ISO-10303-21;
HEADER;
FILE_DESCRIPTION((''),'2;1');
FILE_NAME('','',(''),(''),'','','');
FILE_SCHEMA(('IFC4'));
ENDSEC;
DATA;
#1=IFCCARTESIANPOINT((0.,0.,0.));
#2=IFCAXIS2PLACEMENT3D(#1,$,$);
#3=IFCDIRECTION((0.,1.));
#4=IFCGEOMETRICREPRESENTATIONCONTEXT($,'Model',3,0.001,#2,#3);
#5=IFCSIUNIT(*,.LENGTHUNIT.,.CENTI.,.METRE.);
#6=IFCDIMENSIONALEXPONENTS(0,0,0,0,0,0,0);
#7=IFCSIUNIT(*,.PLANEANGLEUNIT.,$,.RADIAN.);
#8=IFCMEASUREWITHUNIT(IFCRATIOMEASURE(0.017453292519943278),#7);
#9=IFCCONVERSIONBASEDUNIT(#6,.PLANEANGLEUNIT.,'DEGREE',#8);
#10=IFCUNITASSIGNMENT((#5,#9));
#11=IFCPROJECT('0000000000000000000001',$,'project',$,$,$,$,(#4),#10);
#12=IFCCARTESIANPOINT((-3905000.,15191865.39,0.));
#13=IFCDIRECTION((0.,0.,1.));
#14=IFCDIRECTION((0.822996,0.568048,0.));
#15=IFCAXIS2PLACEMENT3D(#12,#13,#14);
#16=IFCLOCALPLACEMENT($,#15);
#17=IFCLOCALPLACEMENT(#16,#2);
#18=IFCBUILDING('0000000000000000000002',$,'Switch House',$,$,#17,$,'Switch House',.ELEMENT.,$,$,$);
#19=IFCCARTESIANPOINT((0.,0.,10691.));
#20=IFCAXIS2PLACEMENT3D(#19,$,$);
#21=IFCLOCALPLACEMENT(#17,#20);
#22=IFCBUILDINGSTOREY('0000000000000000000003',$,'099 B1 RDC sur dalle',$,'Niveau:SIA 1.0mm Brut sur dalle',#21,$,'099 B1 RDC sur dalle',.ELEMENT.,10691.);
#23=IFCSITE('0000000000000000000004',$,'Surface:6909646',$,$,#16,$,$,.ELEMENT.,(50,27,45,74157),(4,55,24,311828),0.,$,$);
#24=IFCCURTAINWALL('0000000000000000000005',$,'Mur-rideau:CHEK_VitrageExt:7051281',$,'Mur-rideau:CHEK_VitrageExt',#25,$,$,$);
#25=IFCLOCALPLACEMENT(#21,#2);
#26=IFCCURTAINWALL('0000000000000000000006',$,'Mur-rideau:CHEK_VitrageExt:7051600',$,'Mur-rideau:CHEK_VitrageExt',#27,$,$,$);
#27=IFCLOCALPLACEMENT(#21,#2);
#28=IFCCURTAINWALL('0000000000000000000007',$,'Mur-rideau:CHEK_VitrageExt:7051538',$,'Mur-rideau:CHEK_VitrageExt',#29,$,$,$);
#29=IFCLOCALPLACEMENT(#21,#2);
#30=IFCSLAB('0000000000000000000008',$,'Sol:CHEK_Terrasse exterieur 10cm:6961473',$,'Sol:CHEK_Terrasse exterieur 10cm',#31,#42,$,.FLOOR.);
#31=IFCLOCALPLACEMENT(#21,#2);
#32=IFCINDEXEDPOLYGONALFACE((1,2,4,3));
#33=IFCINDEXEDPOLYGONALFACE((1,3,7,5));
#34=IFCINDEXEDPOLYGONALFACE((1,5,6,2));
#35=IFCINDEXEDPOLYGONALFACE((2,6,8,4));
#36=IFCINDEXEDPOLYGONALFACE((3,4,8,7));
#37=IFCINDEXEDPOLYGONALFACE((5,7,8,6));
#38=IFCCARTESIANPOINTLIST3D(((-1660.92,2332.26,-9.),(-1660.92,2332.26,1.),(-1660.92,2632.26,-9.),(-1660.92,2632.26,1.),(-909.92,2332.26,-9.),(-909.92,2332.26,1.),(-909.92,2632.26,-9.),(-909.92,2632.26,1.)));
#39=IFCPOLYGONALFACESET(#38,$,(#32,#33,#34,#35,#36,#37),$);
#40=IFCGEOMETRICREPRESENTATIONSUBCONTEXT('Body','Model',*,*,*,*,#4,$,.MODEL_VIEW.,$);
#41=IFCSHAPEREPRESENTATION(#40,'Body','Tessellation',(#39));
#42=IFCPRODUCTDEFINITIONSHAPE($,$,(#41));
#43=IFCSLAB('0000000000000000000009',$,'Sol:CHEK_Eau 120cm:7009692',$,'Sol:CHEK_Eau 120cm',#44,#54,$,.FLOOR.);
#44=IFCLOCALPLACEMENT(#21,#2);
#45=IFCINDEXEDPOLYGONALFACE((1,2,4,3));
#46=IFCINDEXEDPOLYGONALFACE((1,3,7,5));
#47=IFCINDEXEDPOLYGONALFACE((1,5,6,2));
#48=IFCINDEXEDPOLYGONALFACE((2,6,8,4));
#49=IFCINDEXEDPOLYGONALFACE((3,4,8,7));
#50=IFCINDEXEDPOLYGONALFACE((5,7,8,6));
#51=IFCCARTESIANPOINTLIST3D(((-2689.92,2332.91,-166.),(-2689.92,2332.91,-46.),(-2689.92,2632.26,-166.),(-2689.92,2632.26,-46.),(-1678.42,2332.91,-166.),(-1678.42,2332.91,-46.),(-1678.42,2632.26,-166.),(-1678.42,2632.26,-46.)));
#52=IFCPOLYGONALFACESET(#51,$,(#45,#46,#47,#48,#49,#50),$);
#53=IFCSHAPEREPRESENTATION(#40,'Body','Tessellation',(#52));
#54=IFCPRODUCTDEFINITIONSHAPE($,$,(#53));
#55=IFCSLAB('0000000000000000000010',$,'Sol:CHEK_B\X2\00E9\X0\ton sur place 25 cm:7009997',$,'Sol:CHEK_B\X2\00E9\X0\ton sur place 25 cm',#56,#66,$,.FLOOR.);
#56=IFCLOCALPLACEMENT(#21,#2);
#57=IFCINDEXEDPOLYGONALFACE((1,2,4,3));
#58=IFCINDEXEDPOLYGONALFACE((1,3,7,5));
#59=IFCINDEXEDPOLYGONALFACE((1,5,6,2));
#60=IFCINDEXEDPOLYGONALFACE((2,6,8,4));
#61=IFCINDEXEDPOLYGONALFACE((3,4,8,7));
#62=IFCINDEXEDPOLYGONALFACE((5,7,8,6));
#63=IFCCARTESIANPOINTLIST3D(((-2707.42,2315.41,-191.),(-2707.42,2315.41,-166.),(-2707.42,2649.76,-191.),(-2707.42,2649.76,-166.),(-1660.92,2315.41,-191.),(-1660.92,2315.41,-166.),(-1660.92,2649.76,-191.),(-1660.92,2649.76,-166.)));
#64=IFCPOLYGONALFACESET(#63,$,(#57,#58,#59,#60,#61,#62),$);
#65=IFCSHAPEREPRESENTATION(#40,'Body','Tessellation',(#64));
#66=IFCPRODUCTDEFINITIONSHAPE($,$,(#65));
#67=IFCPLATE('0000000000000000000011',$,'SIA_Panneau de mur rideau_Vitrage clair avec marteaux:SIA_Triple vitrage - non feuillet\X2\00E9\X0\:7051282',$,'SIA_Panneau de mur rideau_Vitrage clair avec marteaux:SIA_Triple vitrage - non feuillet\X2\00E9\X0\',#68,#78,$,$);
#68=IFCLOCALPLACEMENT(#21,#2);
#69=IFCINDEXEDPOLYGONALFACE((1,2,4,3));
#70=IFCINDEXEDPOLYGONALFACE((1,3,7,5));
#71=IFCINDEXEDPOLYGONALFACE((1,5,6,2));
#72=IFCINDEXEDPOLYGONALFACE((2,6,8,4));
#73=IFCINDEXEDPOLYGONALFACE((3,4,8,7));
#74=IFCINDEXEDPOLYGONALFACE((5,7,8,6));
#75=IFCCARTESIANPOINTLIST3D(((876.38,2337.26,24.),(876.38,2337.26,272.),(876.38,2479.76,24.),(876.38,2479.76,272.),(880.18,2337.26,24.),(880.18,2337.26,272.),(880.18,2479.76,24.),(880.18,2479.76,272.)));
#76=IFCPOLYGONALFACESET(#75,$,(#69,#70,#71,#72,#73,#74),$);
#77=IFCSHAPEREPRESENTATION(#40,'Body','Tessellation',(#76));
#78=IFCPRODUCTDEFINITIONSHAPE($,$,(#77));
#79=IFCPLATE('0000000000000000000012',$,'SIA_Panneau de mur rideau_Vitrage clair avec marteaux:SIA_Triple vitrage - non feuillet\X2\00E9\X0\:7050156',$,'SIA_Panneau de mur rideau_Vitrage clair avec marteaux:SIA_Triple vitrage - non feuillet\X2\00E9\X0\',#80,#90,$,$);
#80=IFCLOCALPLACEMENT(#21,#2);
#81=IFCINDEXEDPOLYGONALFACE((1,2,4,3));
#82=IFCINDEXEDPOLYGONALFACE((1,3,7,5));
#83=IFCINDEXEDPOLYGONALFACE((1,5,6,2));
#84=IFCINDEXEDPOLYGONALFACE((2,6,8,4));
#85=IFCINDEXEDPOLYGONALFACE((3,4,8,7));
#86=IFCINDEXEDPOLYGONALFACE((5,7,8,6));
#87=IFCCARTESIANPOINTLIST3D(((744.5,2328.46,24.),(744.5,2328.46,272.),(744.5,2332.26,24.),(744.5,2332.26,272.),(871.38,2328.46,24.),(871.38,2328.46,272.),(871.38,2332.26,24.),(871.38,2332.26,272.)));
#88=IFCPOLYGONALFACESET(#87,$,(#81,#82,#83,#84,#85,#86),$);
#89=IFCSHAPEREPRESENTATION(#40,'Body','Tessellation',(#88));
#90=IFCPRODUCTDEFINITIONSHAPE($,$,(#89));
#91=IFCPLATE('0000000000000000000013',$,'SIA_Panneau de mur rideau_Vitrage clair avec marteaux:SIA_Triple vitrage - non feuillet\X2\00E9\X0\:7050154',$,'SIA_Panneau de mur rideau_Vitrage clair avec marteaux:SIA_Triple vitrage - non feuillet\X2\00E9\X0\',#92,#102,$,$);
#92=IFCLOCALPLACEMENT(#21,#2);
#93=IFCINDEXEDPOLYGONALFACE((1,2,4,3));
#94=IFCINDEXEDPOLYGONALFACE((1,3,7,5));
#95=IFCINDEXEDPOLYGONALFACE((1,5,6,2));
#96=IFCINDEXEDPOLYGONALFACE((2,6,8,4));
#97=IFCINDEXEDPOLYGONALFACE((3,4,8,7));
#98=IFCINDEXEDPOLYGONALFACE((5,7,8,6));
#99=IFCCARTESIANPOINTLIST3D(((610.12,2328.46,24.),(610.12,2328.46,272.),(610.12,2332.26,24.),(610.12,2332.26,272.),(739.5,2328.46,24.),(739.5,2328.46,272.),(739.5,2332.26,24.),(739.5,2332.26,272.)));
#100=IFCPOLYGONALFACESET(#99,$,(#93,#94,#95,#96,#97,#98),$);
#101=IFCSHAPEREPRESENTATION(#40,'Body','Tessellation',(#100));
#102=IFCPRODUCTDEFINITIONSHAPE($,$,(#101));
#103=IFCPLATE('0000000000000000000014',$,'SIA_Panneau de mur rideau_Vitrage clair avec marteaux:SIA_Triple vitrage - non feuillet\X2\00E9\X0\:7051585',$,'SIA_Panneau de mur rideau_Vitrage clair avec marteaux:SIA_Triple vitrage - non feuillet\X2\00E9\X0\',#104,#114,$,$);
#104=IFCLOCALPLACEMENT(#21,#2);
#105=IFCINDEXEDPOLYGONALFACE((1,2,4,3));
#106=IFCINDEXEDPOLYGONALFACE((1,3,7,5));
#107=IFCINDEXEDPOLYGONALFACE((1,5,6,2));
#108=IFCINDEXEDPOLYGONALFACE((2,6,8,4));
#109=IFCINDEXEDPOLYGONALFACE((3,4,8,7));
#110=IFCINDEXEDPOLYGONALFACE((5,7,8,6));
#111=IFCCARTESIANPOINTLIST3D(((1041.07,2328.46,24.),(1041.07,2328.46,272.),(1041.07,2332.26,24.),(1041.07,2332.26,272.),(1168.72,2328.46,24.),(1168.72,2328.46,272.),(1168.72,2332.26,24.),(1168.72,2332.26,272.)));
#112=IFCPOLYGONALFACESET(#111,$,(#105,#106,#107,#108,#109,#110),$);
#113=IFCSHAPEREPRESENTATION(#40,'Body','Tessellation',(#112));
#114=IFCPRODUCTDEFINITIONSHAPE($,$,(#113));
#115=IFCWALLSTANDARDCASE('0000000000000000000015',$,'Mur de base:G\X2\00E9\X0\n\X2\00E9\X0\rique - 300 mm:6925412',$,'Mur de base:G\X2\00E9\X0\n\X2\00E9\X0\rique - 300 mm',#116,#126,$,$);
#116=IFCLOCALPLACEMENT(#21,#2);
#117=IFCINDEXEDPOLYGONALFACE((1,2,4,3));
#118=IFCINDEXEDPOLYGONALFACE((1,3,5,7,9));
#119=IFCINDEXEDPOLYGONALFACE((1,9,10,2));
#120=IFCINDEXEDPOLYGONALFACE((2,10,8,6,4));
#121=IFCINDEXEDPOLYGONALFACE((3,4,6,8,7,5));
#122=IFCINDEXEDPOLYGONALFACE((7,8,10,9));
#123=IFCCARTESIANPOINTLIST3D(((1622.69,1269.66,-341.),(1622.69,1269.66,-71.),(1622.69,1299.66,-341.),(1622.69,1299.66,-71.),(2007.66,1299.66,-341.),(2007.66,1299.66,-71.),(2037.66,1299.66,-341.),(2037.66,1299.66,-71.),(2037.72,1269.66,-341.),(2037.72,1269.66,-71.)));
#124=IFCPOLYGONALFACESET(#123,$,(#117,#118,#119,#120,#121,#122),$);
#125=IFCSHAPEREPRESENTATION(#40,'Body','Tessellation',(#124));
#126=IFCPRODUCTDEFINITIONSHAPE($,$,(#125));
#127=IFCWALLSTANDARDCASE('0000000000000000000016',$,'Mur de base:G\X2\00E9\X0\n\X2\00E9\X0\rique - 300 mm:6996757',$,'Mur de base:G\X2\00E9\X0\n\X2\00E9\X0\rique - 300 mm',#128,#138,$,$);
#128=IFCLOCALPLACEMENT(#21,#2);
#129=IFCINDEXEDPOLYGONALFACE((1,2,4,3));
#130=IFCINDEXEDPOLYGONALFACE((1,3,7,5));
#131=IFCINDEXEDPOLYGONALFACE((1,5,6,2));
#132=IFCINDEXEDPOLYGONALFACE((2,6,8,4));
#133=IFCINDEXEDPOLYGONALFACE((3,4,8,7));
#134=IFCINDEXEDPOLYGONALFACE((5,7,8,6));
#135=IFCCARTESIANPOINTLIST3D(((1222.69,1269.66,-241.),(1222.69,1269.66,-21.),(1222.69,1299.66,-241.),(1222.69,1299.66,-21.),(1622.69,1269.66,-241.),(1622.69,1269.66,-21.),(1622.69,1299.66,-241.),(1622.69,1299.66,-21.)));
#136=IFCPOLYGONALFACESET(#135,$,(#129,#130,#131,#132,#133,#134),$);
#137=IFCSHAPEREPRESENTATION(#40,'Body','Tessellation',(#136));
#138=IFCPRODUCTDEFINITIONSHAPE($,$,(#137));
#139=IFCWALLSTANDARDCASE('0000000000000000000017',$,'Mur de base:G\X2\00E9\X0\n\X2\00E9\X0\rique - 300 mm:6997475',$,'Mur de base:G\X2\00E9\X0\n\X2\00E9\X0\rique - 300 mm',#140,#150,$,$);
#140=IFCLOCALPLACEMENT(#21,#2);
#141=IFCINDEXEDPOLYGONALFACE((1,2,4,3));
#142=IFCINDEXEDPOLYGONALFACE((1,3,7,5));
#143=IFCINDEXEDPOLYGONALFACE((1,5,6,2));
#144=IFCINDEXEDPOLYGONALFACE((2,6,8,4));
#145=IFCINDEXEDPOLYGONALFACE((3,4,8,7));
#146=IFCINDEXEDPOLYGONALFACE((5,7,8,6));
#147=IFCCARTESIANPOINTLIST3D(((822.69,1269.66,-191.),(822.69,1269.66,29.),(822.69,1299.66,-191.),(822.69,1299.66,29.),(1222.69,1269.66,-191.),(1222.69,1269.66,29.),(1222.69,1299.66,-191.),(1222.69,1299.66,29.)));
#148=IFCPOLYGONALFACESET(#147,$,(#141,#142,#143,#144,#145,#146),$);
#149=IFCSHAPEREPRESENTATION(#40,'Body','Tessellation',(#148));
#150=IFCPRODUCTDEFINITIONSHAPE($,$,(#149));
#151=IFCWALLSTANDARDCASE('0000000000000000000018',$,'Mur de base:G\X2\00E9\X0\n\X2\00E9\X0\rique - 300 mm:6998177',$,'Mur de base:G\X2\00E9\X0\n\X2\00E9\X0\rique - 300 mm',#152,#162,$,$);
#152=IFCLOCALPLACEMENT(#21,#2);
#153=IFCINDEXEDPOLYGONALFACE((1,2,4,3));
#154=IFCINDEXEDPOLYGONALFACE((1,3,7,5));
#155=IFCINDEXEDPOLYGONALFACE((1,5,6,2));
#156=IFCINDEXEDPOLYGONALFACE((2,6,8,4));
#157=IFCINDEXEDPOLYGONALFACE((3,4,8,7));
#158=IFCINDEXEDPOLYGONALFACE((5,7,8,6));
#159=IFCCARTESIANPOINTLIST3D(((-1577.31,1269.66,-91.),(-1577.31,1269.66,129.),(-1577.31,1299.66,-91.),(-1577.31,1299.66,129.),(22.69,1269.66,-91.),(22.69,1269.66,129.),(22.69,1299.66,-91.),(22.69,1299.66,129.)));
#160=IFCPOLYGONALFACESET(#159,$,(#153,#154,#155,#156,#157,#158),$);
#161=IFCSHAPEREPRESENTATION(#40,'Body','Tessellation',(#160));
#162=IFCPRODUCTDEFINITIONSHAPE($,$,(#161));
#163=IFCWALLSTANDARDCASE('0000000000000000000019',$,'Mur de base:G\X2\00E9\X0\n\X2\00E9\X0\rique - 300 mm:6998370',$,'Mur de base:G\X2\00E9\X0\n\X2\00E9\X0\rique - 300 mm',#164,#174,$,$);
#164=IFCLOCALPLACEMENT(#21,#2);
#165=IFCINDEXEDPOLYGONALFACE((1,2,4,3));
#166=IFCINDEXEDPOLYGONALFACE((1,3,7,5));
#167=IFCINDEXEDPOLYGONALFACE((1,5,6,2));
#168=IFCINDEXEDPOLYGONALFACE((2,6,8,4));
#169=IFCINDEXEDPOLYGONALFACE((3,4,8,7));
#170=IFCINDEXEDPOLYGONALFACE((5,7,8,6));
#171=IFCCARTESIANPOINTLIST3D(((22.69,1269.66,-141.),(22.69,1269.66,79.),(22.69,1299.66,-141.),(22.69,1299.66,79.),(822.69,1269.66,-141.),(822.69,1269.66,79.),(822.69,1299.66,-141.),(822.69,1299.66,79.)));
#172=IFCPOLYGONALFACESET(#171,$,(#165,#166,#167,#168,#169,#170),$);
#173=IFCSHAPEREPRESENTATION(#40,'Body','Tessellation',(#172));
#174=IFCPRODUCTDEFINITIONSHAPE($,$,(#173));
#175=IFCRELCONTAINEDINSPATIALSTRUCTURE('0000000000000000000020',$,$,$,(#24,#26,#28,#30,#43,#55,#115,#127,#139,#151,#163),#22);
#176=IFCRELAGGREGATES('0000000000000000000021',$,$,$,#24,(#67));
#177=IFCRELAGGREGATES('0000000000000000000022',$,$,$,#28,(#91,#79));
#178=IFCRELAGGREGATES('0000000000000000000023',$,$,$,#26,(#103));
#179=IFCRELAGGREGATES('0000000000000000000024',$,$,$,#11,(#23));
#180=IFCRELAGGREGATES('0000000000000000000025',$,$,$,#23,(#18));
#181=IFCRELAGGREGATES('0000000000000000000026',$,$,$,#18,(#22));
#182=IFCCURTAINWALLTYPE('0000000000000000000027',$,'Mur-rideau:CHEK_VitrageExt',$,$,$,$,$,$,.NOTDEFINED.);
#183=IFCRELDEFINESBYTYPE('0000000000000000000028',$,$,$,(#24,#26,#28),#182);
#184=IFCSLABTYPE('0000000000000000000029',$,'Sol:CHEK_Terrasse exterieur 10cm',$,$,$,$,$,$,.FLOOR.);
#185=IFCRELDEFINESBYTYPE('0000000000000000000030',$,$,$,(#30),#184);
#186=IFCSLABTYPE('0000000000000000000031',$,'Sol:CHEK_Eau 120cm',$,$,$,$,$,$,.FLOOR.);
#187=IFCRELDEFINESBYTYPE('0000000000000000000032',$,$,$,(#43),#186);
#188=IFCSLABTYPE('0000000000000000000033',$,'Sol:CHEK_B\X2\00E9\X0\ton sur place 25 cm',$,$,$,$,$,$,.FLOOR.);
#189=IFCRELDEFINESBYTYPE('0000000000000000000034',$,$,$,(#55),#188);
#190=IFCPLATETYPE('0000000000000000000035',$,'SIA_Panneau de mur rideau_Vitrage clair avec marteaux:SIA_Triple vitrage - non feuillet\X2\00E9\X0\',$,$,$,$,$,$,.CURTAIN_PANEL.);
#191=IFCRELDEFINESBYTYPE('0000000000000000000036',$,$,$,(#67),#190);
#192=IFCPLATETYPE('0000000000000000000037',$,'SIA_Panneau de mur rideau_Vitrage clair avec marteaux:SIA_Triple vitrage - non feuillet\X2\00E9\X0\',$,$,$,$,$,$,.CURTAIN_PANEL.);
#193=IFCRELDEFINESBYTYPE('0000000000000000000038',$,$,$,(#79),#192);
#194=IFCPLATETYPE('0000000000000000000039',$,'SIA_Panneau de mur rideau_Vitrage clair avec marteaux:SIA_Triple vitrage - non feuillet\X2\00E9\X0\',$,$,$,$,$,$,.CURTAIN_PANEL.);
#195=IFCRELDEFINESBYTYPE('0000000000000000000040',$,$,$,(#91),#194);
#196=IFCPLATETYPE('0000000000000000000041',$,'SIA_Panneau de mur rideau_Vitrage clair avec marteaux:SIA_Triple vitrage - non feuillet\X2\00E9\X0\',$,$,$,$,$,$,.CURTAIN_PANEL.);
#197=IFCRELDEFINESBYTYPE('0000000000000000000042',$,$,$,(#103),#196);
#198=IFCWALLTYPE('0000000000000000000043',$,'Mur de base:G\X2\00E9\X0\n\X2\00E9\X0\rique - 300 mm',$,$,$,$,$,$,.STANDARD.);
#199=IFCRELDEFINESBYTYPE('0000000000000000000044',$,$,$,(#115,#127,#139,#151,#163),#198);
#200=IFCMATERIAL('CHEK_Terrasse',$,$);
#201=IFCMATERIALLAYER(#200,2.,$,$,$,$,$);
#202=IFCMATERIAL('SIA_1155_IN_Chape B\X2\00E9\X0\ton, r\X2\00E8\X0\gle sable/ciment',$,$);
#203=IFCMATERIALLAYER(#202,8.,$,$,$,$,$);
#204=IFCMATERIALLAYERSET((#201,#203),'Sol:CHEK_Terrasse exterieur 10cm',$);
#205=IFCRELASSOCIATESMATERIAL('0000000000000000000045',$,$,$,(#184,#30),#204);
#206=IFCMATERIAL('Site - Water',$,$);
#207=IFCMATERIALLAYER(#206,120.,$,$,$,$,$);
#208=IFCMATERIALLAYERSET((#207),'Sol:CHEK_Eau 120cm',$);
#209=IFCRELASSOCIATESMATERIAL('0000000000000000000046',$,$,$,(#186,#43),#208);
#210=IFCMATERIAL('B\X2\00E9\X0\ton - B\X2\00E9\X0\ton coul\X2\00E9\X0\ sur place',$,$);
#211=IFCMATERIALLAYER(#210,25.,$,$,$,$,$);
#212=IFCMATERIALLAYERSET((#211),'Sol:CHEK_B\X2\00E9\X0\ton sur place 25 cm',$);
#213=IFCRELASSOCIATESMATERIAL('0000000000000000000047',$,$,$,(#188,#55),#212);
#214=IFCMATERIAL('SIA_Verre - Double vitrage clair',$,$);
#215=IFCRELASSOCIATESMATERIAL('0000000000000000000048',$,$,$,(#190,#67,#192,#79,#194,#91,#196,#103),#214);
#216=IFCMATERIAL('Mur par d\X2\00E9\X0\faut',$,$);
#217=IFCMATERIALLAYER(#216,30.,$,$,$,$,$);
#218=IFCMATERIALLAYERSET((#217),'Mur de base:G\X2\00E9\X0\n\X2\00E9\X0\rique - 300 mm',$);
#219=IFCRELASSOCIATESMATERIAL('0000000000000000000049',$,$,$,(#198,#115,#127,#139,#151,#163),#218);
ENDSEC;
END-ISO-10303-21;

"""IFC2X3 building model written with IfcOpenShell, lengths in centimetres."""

from ifc_helpers import new_model, entity, si_unit, converted_unit, direction, frame, frame_2d, origin, origin_2d_with_axis, place, context, subcontext, project, spatial, polyline, rectangle, outline, extrude, source, transform, mapped, material, layer, layer_set, layer_usage, type_object, type_shapes, element, aggregate, save


model = new_model("IFC2X3")

# Units and contexts
model_context = context("Model", 3, precision=0.001, world=origin(), true_north=direction((0.0, 1.0)))
body_context = subcontext(model_context, "Body", "Model", "MODEL_VIEW")
ifc_project = project(units=[si_unit("LENGTHUNIT", "METRE", prefix="CENTI"), converted_unit("PLANEANGLEUNIT", "DEGREE", entity("IfcRatioMeasure", 0.017453292519943278), si_unit("PLANEANGLEUNIT", "RADIAN"), dimensions=[0, 0, 0, 0, 0, 0, 0])], contexts=[model_context])

# Site, building, storey
site_placement = place(None, frame((-3905000.0, 15191865.39, 0.0), z_axis=(0.0, 0.0, 1.0), x_axis=(0.822996, 0.568048, 0.0)))
site = spatial("IfcSite", under=ifc_project, at=site_placement, Name="Surface:6909646", CompositionType="ELEMENT", RefLatitude=(50, 27, 45, 74157), RefLongitude=(4, 55, 24, 311828), RefElevation=0.0)
building_placement = place(site_placement, origin())
building = spatial("IfcBuilding", under=site, at=building_placement, Name="Switch House", LongName="Switch House", CompositionType="ELEMENT")
storey_placement = place(building_placement, frame((0.0, 0.0, 10691.0)))
storey = spatial("IfcBuildingStorey", under=building, at=storey_placement, Name="099 B1 RDC sur dalle", ObjectType="Niveau:SIA 1.0mm Brut sur dalle", LongName="099 B1 RDC sur dalle", CompositionType="ELEMENT", Elevation=10691.0)

# Curtain walls
curtain_wall_type = type_object("IfcCurtainWallType", Name="Mur-rideau:CHEK_VitrageExt", PredefinedType="NOTDEFINED")
curtain_wall_1_placement = place(storey_placement, frame((0.0, 0.0, -10691.0)))
curtain_wall_1 = element("IfcCurtainWall", 1, at=curtain_wall_1_placement, inside=storey, type_object=curtain_wall_type, Name="Mur-rideau:CHEK_VitrageExt:7051281", ObjectType="Mur-rideau:CHEK_VitrageExt")
curtain_wall_2_placement = place(storey_placement, frame((0.0, 0.0, -10691.0)))
curtain_wall_2 = element("IfcCurtainWall", 2, at=curtain_wall_2_placement, inside=storey, type_object=curtain_wall_type, Name="Mur-rideau:CHEK_VitrageExt:7051600", ObjectType="Mur-rideau:CHEK_VitrageExt")

# Curtain wall
curtain_wall_3_placement = place(storey_placement, frame((0.0, 0.0, -10691.0)))
curtain_wall_3 = element("IfcCurtainWall", 3, at=curtain_wall_3_placement, inside=storey, type_object=curtain_wall_type, Name="Mur-rideau:CHEK_VitrageExt:7051538", ObjectType="Mur-rideau:CHEK_VitrageExt")

# Slabs
ifc_material_1 = material(Name="CHEK_Terrasse")
ifc_layer_1 = layer(ifc_material_1, 2.0)
ifc_material_2 = material(Name="SIA_1155_IN_Chape Béton, règle sable/ciment")
ifc_layer_2 = layer(ifc_material_2, 8.0)
ifc_layer_set_1 = layer_set([ifc_layer_1, ifc_layer_2], Name="Sol:CHEK_Terrasse exterieur 10cm")
ifc_layer_usage_1 = layer_usage(ifc_layer_set_1, "AXIS3", "POSITIVE", 0.0)
slab_type_1 = type_object("IfcSlabType", Name="Sol:CHEK_Terrasse exterieur 10cm", PredefinedType="FLOOR", material=ifc_layer_set_1)
slab_1_placement = place(storey_placement, origin())
element("IfcSlab", 4, at=slab_1_placement, inside=storey, type_object=slab_type_1, material=ifc_layer_usage_1, Name="Sol:CHEK_Terrasse exterieur 10cm:6961473", ObjectType="Sol:CHEK_Terrasse exterieur 10cm", PredefinedType="FLOOR", context=body_context, shape_type="SweptSolid", body=[
    extrude(rectangle(XDim=300.0, YDim=751.0, at=frame_2d((0.0, 0.0), x_axis=(1.0, 0.0))), frame((-1285.42, 2482.26, 1.0), z_axis=(0.0, 0.0, -1.0), x_axis=(0.0, 1.0, 0.0)), (0.0, 0.0, 1.0), 10.0),
])
ifc_material_3 = material(Name="Site - Water")
ifc_layer_3 = layer(ifc_material_3, 120.0)
ifc_layer_set_2 = layer_set([ifc_layer_3], Name="Sol:CHEK_Eau 120cm")
ifc_layer_usage_2 = layer_usage(ifc_layer_set_2, "AXIS3", "POSITIVE", 0.0)
slab_type_2 = type_object("IfcSlabType", Name="Sol:CHEK_Eau 120cm", PredefinedType="FLOOR", material=ifc_layer_set_2)
slab_2_placement = place(storey_placement, origin())
element("IfcSlab", 5, at=slab_2_placement, inside=storey, type_object=slab_type_2, material=ifc_layer_usage_2, Name="Sol:CHEK_Eau 120cm:7009692", ObjectType="Sol:CHEK_Eau 120cm", PredefinedType="FLOOR", context=body_context, shape_type="SweptSolid", body=[
    extrude(rectangle(XDim=299.35, YDim=1011.5, at=frame_2d((0.0, 0.0), x_axis=(1.0, 0.0))), frame((-2184.17, 2482.59, -46.0), z_axis=(0.0, 0.0, -1.0), x_axis=(0.0, 1.0, 0.0)), (0.0, 0.0, 1.0), 120.0),
])
ifc_material_4 = material(Name="Béton - Béton coulé sur place")
ifc_layer_4 = layer(ifc_material_4, 25.0)
ifc_layer_set_3 = layer_set([ifc_layer_4], Name="Sol:CHEK_Béton sur place 25 cm")
ifc_layer_usage_3 = layer_usage(ifc_layer_set_3, "AXIS3", "POSITIVE", 0.0)
slab_type_3 = type_object("IfcSlabType", Name="Sol:CHEK_Béton sur place 25 cm", PredefinedType="FLOOR", material=ifc_layer_set_3)
slab_3_placement = place(storey_placement, origin())
element("IfcSlab", 6, at=slab_3_placement, inside=storey, type_object=slab_type_3, material=ifc_layer_usage_3, Name="Sol:CHEK_Béton sur place 25 cm:7009997", ObjectType="Sol:CHEK_Béton sur place 25 cm", PredefinedType="FLOOR", context=body_context, shape_type="SweptSolid", body=[
    extrude(rectangle(XDim=334.35, YDim=1046.5, at=frame_2d((0.0, 0.0), x_axis=(1.0, 0.0))), frame((-2184.17, 2482.59, -166.0), z_axis=(0.0, 0.0, -1.0), x_axis=(0.0, 1.0, 0.0)), (0.0, 0.0, 1.0), 25.0),
])

# Plates
ifc_material_5 = material(Name="SIA_Verre - Double vitrage clair")
plate_type_1 = type_object("IfcPlateType", Name="SIA_Panneau de mur rideau_Vitrage clair avec marteaux:SIA_Triple vitrage - non feuilleté", PredefinedType="CURTAIN_PANEL", material=ifc_material_5)
shared_shape_1 = source(origin(), body_context, "Body", "SweptSolid", [
    extrude(rectangle(XDim=3.8, YDim=142.5, at=origin_2d_with_axis()), frame((0.0, -1.9, 0.0), z_axis=(0.0, 0.0, 1.0), x_axis=(0.0, 1.0, 0.0)), (0.0, 0.0, 1.0), 248.0),
])
type_shapes(plate_type_1, [shared_shape_1])
plate_1_placement = place(curtain_wall_1_placement, frame((876.38, 2408.51, 10715.0), z_axis=(0.0, 0.0, 1.0), x_axis=(0.0, 1.0, 0.0)))
plate_1 = element("IfcPlate", 7, at=plate_1_placement, type_object=plate_type_1, material=ifc_material_5, Name="SIA_Panneau de mur rideau_Vitrage clair avec marteaux:SIA_Triple vitrage - non feuilleté:7051282", ObjectType="SIA_Panneau de mur rideau_Vitrage clair avec marteaux:SIA_Triple vitrage - non feuilleté", context=body_context, shape_type="MappedRepresentation", body=[
    mapped(shared_shape_1, transform((0.0, 0.0, 0.0), scale=1.0)),
])
aggregate(curtain_wall_1, [plate_1])
plate_type_2 = type_object("IfcPlateType", Name="SIA_Panneau de mur rideau_Vitrage clair avec marteaux:SIA_Triple vitrage - non feuilleté", PredefinedType="CURTAIN_PANEL", material=ifc_material_5)
shared_shape_2 = source(origin(), body_context, "Body", "SweptSolid", [
    extrude(rectangle(XDim=3.8, YDim=126.88, at=origin_2d_with_axis()), frame((0.0, -1.9, 0.0), z_axis=(0.0, 0.0, 1.0), x_axis=(0.0, 1.0, 0.0)), (0.0, 0.0, 1.0), 248.0),
])
type_shapes(plate_type_2, [shared_shape_2])
plate_2_placement = place(curtain_wall_3_placement, frame((807.94, 2332.26, 10715.0)))
plate_2 = element("IfcPlate", 8, at=plate_2_placement, type_object=plate_type_2, material=ifc_material_5, Name="SIA_Panneau de mur rideau_Vitrage clair avec marteaux:SIA_Triple vitrage - non feuilleté:7050156", ObjectType="SIA_Panneau de mur rideau_Vitrage clair avec marteaux:SIA_Triple vitrage - non feuilleté", context=body_context, shape_type="MappedRepresentation", body=[
    mapped(shared_shape_2, transform((0.0, 0.0, 0.0), scale=1.0)),
])
plate_type_3 = type_object("IfcPlateType", Name="SIA_Panneau de mur rideau_Vitrage clair avec marteaux:SIA_Triple vitrage - non feuilleté", PredefinedType="CURTAIN_PANEL", material=ifc_material_5)
shared_shape_3 = source(origin(), body_context, "Body", "SweptSolid", [
    extrude(rectangle(XDim=3.8, YDim=129.38, at=origin_2d_with_axis()), frame((0.0, -1.9, 0.0), z_axis=(0.0, 0.0, 1.0), x_axis=(0.0, 1.0, 0.0)), (0.0, 0.0, 1.0), 248.0),
])
type_shapes(plate_type_3, [shared_shape_3])
plate_3_placement = place(curtain_wall_3_placement, frame((674.81, 2332.26, 10715.0)))
plate_3 = element("IfcPlate", 9, at=plate_3_placement, type_object=plate_type_3, material=ifc_material_5, Name="SIA_Panneau de mur rideau_Vitrage clair avec marteaux:SIA_Triple vitrage - non feuilleté:7050154", ObjectType="SIA_Panneau de mur rideau_Vitrage clair avec marteaux:SIA_Triple vitrage - non feuilleté", context=body_context, shape_type="MappedRepresentation", body=[
    mapped(shared_shape_3, transform((0.0, 0.0, 0.0), scale=1.0)),
])
aggregate(curtain_wall_3, [plate_3, plate_2])
plate_type_4 = type_object("IfcPlateType", Name="SIA_Panneau de mur rideau_Vitrage clair avec marteaux:SIA_Triple vitrage - non feuilleté", PredefinedType="CURTAIN_PANEL", material=ifc_material_5)
shared_shape_4 = source(origin(), body_context, "Body", "SweptSolid", [
    extrude(rectangle(XDim=3.8, YDim=127.65, at=origin_2d_with_axis()), frame((0.0, -1.9, 0.0), z_axis=(0.0, 0.0, 1.0), x_axis=(0.0, 1.0, 0.0)), (0.0, 0.0, 1.0), 248.0),
])
type_shapes(plate_type_4, [shared_shape_4])
plate_4_placement = place(curtain_wall_2_placement, frame((1104.9, 2332.26, 10715.0)))
plate_4 = element("IfcPlate", 10, at=plate_4_placement, type_object=plate_type_4, material=ifc_material_5, Name="SIA_Panneau de mur rideau_Vitrage clair avec marteaux:SIA_Triple vitrage - non feuilleté:7051585", ObjectType="SIA_Panneau de mur rideau_Vitrage clair avec marteaux:SIA_Triple vitrage - non feuilleté", context=body_context, shape_type="MappedRepresentation", body=[
    mapped(shared_shape_4, transform((0.0, 0.0, 0.0), scale=1.0)),
])
aggregate(curtain_wall_2, [plate_4])

# Walls
ifc_material_6 = material(Name="Mur par défaut")
ifc_layer_5 = layer(ifc_material_6, 30.0)
ifc_layer_set_4 = layer_set([ifc_layer_5], Name="Mur de base:Générique - 300 mm")
ifc_layer_usage_4 = layer_usage(ifc_layer_set_4, "AXIS2", "POSITIVE", -15.0)
wall_type_1 = type_object("IfcWallType", Name="Mur de base:Générique - 300 mm", PredefinedType="STANDARD", material=ifc_layer_set_4)
wall_1_placement = place(storey_placement, frame((2037.72, 1284.66, -341.0), z_axis=(0.0, 0.0, 1.0), x_axis=(-1.0, 0.0, 0.0)))
element("IfcWallStandardCase", 11, at=wall_1_placement, inside=storey, type_object=wall_type_1, material=ifc_layer_usage_4, Name="Mur de base:Générique - 300 mm:6925412", ObjectType="Mur de base:Générique - 300 mm", context=body_context, shape_type="SweptSolid", body=[
    extrude(outline(polyline([(415.03, -15.0), (415.03, 15.0), (0.0, 15.0), (0.07, -15.0), (30.07, -15.0), (415.03, -15.0)])), origin(), (0.0, 0.0, 1.0), 270.0),
])
ifc_layer_usage_5 = layer_usage(ifc_layer_set_4, "AXIS2", "NEGATIVE", 15.0)
wall_2_placement = place(storey_placement, frame((1622.69, 1284.66, -241.0), z_axis=(0.0, 0.0, 1.0), x_axis=(-1.0, 0.0, 0.0)))
element("IfcWallStandardCase", 12, at=wall_2_placement, inside=storey, type_object=wall_type_1, material=ifc_layer_usage_5, Name="Mur de base:Générique - 300 mm:6996757", ObjectType="Mur de base:Générique - 300 mm", context=body_context, shape_type="SweptSolid", body=[
    extrude(rectangle(XDim=400.0, YDim=30.0, at=frame_2d((200.0, 0.0), x_axis=(-1.0, 0.0))), origin(), (0.0, 0.0, 1.0), 220.0),
])
wall_3_placement = place(storey_placement, frame((1222.69, 1284.66, -191.0), z_axis=(0.0, 0.0, 1.0), x_axis=(-1.0, 0.0, 0.0)))
element("IfcWallStandardCase", 13, at=wall_3_placement, inside=storey, type_object=wall_type_1, material=ifc_layer_usage_5, Name="Mur de base:Générique - 300 mm:6997475", ObjectType="Mur de base:Générique - 300 mm", context=body_context, shape_type="SweptSolid", body=[
    extrude(rectangle(XDim=400.0, YDim=30.0, at=frame_2d((200.0, 0.0), x_axis=(-1.0, 0.0))), origin(), (0.0, 0.0, 1.0), 220.0),
])
wall_4_placement = place(storey_placement, frame((22.69, 1284.66, -91.0), z_axis=(0.0, 0.0, 1.0), x_axis=(-1.0, 0.0, 0.0)))
element("IfcWallStandardCase", 14, at=wall_4_placement, inside=storey, type_object=wall_type_1, material=ifc_layer_usage_5, Name="Mur de base:Générique - 300 mm:6998177", ObjectType="Mur de base:Générique - 300 mm", context=body_context, shape_type="SweptSolid", body=[
    extrude(rectangle(XDim=1600.0, YDim=30.0, at=frame_2d((800.0, 0.0), x_axis=(-1.0, 0.0))), origin(), (0.0, 0.0, 1.0), 220.0),
])
wall_5_placement = place(storey_placement, frame((822.69, 1284.66, -141.0), z_axis=(0.0, 0.0, 1.0), x_axis=(-1.0, 0.0, 0.0)))
element("IfcWallStandardCase", 15, at=wall_5_placement, inside=storey, type_object=wall_type_1, material=ifc_layer_usage_5, Name="Mur de base:Générique - 300 mm:6998370", ObjectType="Mur de base:Générique - 300 mm", context=body_context, shape_type="SweptSolid", body=[
    extrude(rectangle(XDim=800.0, YDim=30.0, at=frame_2d((400.0, 0.0), x_axis=(-1.0, 0.0))), origin(), (0.0, 0.0, 1.0), 220.0),
])

save(model, "model.ifc")
